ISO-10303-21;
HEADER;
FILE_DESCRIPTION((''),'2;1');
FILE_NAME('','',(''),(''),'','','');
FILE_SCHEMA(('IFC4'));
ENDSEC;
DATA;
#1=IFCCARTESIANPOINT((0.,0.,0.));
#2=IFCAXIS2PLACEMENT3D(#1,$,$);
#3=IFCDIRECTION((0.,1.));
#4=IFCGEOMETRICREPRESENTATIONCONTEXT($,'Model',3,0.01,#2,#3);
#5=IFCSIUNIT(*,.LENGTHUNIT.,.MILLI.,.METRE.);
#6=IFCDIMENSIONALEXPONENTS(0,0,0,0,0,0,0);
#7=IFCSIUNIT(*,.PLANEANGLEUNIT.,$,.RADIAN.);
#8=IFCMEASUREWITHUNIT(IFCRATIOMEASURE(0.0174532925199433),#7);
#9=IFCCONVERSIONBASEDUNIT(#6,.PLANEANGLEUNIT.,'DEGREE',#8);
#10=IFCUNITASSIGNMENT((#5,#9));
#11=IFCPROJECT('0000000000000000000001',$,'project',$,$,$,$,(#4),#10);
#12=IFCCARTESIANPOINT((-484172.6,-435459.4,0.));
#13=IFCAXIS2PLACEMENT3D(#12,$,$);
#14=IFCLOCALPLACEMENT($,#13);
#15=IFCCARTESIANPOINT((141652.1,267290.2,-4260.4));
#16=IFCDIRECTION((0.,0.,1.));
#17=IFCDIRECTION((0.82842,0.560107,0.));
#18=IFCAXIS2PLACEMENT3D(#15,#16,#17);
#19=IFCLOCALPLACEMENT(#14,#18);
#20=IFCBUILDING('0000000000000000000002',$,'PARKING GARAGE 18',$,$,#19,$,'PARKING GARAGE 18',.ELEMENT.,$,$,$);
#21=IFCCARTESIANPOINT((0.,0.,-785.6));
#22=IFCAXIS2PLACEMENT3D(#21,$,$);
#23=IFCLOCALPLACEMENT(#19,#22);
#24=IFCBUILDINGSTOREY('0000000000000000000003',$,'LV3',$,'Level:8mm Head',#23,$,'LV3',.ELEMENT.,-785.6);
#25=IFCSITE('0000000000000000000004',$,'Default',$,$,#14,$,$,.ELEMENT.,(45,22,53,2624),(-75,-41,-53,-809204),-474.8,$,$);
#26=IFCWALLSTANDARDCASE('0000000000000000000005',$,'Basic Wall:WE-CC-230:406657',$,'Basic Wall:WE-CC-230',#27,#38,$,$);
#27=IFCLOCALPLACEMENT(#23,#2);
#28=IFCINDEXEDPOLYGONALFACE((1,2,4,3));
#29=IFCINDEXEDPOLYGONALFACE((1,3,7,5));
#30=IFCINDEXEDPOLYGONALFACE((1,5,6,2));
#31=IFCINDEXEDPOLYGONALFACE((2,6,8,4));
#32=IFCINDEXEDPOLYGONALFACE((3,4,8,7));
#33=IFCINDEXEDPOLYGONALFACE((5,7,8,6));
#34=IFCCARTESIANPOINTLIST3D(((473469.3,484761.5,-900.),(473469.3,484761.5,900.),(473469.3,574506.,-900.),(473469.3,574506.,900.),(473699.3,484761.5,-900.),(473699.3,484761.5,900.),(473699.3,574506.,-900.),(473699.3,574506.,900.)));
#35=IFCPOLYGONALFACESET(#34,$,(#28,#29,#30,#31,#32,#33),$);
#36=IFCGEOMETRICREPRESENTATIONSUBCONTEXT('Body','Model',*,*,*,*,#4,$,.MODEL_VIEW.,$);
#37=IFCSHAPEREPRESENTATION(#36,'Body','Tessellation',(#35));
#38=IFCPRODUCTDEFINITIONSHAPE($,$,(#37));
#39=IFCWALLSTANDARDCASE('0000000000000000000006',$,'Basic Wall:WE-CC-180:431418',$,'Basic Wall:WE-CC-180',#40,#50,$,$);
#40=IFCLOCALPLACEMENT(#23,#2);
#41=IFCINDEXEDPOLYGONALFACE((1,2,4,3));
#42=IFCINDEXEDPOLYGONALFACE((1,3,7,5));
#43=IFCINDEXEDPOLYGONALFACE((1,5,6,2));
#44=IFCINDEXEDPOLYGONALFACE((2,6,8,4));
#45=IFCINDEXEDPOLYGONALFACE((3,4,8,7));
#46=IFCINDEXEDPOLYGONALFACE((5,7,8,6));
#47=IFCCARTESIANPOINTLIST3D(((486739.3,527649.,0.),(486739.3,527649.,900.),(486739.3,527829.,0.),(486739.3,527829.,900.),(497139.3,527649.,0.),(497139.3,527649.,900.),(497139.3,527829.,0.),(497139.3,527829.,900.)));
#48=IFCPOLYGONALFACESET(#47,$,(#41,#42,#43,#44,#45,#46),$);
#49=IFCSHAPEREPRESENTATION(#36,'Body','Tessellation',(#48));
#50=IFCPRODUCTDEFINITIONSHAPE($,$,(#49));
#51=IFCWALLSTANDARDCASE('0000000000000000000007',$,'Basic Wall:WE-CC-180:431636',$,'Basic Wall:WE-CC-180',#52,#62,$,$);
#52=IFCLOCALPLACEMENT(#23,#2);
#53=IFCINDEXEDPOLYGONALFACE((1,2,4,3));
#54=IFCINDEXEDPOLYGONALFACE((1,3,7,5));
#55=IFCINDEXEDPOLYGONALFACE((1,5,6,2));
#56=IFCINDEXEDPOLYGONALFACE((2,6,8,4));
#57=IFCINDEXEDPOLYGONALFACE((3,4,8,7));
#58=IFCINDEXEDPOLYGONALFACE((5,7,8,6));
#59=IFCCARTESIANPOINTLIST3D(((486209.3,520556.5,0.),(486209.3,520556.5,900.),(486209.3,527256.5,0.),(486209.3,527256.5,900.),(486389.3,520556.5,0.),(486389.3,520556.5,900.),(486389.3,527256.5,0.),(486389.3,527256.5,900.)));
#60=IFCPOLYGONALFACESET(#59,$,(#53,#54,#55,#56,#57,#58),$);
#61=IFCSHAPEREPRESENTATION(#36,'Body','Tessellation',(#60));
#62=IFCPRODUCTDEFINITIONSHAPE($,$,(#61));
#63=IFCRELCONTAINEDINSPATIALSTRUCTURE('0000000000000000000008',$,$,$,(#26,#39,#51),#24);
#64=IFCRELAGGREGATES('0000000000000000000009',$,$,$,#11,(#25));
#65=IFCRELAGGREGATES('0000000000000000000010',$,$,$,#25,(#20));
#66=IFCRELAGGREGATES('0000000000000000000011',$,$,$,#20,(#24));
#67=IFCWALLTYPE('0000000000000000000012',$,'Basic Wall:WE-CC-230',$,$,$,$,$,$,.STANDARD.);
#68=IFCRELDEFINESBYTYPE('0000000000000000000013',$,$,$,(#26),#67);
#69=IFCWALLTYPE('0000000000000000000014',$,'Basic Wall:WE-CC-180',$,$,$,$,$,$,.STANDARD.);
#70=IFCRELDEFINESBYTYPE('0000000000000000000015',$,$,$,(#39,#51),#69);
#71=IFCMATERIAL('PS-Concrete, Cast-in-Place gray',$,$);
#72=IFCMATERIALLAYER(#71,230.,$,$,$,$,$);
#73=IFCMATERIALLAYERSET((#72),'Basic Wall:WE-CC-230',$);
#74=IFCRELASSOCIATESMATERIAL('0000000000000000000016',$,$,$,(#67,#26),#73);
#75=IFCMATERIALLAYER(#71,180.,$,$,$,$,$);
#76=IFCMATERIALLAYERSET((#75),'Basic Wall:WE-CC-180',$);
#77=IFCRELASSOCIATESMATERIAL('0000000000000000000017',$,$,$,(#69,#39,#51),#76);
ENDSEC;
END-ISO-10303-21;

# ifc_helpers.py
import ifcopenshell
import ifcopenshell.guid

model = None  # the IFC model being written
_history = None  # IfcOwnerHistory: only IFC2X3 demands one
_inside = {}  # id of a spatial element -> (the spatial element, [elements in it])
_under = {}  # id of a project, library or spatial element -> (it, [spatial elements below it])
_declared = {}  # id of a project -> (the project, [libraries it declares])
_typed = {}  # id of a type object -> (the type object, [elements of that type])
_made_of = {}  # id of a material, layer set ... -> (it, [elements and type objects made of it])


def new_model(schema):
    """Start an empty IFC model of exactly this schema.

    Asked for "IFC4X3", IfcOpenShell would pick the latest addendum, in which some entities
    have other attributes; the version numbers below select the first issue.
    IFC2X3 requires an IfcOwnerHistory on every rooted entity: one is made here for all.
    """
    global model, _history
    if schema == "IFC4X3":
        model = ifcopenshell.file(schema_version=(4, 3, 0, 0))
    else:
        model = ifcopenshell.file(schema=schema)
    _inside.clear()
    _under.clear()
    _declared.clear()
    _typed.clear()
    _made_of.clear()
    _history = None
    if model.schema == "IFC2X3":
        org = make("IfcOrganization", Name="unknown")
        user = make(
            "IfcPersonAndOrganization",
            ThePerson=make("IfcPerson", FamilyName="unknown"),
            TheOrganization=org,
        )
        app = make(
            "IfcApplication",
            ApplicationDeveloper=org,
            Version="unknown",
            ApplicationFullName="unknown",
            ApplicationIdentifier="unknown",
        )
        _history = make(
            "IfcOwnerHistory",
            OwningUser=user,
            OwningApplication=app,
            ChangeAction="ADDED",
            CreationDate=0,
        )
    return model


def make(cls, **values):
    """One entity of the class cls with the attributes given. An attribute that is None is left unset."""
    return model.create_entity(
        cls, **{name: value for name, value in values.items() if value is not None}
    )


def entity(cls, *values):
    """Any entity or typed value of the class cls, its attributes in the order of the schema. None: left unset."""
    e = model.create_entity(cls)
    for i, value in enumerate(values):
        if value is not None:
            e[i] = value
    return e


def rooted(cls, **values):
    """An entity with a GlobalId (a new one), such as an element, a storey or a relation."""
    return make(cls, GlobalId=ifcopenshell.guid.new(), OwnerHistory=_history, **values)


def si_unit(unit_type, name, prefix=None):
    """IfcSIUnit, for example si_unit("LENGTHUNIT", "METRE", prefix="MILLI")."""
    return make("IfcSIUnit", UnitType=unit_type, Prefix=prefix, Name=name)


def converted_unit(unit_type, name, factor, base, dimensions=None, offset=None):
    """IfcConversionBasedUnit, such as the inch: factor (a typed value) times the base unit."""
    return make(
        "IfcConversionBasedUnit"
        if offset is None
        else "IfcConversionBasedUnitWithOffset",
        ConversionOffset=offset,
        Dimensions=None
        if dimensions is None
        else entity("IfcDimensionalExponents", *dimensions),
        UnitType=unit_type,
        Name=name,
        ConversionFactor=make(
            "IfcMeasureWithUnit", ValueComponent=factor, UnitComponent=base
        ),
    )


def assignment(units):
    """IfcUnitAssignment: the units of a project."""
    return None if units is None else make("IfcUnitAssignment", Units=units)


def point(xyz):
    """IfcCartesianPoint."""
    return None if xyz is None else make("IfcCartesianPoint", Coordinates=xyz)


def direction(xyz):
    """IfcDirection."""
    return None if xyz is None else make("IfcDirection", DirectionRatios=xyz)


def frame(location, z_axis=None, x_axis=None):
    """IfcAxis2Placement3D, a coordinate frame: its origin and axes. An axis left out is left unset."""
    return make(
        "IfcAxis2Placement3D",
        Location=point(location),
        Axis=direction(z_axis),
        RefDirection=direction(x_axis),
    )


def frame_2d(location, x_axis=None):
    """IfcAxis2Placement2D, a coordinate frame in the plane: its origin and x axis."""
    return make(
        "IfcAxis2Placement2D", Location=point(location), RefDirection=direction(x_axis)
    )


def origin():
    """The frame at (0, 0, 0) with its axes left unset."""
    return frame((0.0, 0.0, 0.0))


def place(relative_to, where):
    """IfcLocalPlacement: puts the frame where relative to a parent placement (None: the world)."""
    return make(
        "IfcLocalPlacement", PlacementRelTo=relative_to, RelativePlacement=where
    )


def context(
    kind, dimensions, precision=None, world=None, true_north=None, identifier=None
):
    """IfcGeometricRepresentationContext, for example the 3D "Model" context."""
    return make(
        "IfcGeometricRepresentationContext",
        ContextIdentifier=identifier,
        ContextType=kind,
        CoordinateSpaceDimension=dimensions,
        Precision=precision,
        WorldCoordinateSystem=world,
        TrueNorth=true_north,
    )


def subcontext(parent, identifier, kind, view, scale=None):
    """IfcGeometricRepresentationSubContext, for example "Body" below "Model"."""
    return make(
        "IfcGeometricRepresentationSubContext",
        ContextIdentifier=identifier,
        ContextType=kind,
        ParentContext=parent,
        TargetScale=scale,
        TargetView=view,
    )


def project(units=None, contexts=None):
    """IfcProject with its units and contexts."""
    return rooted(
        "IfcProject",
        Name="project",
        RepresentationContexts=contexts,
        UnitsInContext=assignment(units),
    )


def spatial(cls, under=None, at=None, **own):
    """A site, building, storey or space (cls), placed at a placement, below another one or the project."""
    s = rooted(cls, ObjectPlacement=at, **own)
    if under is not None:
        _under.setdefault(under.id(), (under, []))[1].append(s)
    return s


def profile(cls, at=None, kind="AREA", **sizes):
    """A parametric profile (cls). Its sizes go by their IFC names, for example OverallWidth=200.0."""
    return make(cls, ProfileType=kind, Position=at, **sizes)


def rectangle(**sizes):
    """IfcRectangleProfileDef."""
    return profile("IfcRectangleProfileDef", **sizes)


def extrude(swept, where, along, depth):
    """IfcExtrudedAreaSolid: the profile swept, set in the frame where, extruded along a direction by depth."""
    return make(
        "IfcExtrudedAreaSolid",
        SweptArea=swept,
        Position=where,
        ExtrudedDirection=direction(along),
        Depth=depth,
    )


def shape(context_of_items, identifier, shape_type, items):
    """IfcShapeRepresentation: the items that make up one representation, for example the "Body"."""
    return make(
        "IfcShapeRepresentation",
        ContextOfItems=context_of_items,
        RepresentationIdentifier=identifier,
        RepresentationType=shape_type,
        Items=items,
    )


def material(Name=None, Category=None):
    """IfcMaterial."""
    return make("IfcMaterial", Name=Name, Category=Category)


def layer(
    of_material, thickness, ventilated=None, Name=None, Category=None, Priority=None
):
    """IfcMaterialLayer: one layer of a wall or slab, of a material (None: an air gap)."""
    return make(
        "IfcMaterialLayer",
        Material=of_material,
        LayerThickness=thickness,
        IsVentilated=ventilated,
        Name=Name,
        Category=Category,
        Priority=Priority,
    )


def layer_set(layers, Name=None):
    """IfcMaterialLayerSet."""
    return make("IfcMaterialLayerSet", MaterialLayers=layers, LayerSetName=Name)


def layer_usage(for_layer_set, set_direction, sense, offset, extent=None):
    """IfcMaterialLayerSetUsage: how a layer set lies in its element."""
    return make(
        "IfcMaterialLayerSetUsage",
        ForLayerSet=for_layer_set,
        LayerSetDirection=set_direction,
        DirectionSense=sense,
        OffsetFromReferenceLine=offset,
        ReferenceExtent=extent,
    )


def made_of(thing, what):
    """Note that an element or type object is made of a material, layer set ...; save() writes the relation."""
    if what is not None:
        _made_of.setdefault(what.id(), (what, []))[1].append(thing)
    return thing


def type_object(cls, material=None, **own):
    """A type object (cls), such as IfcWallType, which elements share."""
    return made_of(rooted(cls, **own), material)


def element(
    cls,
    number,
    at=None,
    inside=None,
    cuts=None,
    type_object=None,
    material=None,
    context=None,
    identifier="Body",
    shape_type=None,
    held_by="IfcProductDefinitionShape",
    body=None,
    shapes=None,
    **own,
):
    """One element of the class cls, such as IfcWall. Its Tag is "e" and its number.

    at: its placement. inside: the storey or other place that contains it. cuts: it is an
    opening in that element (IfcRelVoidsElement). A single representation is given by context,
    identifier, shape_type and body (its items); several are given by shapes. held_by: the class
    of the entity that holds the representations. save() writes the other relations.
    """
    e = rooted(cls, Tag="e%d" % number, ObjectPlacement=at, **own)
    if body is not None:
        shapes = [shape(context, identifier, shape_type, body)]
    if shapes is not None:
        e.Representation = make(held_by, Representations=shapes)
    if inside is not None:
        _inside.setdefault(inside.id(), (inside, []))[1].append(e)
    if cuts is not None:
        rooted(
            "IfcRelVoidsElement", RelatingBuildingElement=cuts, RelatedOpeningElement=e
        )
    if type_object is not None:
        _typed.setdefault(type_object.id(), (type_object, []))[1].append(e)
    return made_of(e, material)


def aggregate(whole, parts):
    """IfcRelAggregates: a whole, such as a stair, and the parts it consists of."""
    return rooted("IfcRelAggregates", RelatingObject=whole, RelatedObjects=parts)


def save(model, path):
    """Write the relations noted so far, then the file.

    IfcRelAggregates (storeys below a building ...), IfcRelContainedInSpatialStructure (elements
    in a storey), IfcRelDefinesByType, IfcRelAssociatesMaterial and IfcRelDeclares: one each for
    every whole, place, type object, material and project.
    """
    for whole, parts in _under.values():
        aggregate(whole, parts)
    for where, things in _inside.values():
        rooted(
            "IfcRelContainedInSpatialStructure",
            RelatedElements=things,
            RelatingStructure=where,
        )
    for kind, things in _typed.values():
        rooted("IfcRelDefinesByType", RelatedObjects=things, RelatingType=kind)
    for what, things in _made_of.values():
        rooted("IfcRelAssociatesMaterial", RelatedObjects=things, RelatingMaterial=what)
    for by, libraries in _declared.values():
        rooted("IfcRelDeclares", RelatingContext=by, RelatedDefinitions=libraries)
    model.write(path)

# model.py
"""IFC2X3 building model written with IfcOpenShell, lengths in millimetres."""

from ifc_helpers import new_model, entity, si_unit, converted_unit, direction, frame, frame_2d, origin, place, context, subcontext, project, spatial, rectangle, extrude, material, layer, layer_set, layer_usage, type_object, element, save


model = new_model("IFC2X3")

# Units and contexts
model_context = context("Model", 3, precision=0.01, world=origin(), true_north=direction((0.0, 1.0)))
body_context = subcontext(model_context, "Body", "Model", "MODEL_VIEW")
ifc_project = project(units=[si_unit("LENGTHUNIT", "METRE", prefix="MILLI"), converted_unit("PLANEANGLEUNIT", "DEGREE", entity("IfcRatioMeasure", 0.0174532925199433), si_unit("PLANEANGLEUNIT", "RADIAN"), dimensions=[0, 0, 0, 0, 0, 0, 0])], contexts=[model_context])

# Site, building, storey
site_placement = place(None, frame((-484172.6, -435459.4, 0.0)))
site = spatial("IfcSite", under=ifc_project, at=site_placement, Name="Default", CompositionType="ELEMENT", RefLatitude=(45, 22, 53, 2624), RefLongitude=(-75, -41, -53, -809204), RefElevation=-474.8)
building_placement = place(site_placement, frame((141652.1, 267290.2, -4260.4), z_axis=(0.0, 0.0, 1.0), x_axis=(0.82842, 0.560107, 0.0)))
building = spatial("IfcBuilding", under=site, at=building_placement, Name="PARKING GARAGE 18", LongName="PARKING GARAGE 18", CompositionType="ELEMENT")
storey_placement = place(building_placement, frame((0.0, 0.0, -785.6)))
storey = spatial("IfcBuildingStorey", under=building, at=storey_placement, Name="LV3", ObjectType="Level:8mm Head", LongName="LV3", CompositionType="ELEMENT", Elevation=-785.6)

# Walls
ifc_material_1 = material(Name="PS-Concrete, Cast-in-Place gray")
ifc_layer_1 = layer(ifc_material_1, 230.0)
ifc_layer_set_1 = layer_set([ifc_layer_1], Name="Basic Wall:WE-CC-230")
ifc_layer_usage_1 = layer_usage(ifc_layer_set_1, "AXIS2", "NEGATIVE", 115.0)
wall_type_1 = type_object("IfcWallType", Name="Basic Wall:WE-CC-230", PredefinedType="STANDARD", material=ifc_layer_set_1)
wall_1_placement = place(storey_placement, frame((473584.3, 574506.0, -900.0), z_axis=(0.0, 0.0, 1.0), x_axis=(0.0, -1.0, 0.0)))
element("IfcWallStandardCase", 1, at=wall_1_placement, inside=storey, type_object=wall_type_1, material=ifc_layer_usage_1, Name="Basic Wall:WE-CC-230:406657", ObjectType="Basic Wall:WE-CC-230", context=body_context, shape_type="SweptSolid", body=[
    extrude(rectangle(XDim=89744.5, YDim=230.0, at=frame_2d((44872.3, 0.0), x_axis=(-1.0, 0.0))), origin(), (0.0, 0.0, 1.0), 1800.0),
])
ifc_layer_2 = layer(ifc_material_1, 180.0)
ifc_layer_set_2 = layer_set([ifc_layer_2], Name="Basic Wall:WE-CC-180")
ifc_layer_usage_2 = layer_usage(ifc_layer_set_2, "AXIS2", "NEGATIVE", 90.0)
wall_type_2 = type_object("IfcWallType", Name="Basic Wall:WE-CC-180", PredefinedType="STANDARD", material=ifc_layer_set_2)
wall_2_placement = place(storey_placement, frame((497139.3, 527739.0, 0.0), z_axis=(0.0, 0.0, 1.0), x_axis=(-1.0, 0.0, 0.0)))
element("IfcWallStandardCase", 2, at=wall_2_placement, inside=storey, type_object=wall_type_2, material=ifc_layer_usage_2, Name="Basic Wall:WE-CC-180:431418", ObjectType="Basic Wall:WE-CC-180", context=body_context, shape_type="SweptSolid", body=[
    extrude(rectangle(XDim=10400.0, YDim=180.0, at=frame_2d((5200.0, 0.0), x_axis=(-1.0, 0.0))), origin(), (0.0, 0.0, 1.0), 900.0),
])
ifc_layer_usage_3 = layer_usage(ifc_layer_set_2, "AXIS2", "NEGATIVE", 90.0)
wall_3_placement = place(storey_placement, frame((486299.3, 527256.5, 0.0), z_axis=(0.0, 0.0, 1.0), x_axis=(0.0, -1.0, 0.0)))
element("IfcWallStandardCase", 3, at=wall_3_placement, inside=storey, type_object=wall_type_2, material=ifc_layer_usage_3, Name="Basic Wall:WE-CC-180:431636", ObjectType="Basic Wall:WE-CC-180", context=body_context, shape_type="SweptSolid", body=[
    extrude(rectangle(XDim=6700.0, YDim=180.0, at=frame_2d((3350.0, 0.0), x_axis=(-1.0, 0.0))), origin(), (0.0, 0.0, 1.0), 900.0),
])

save(model, "model.ifc")
